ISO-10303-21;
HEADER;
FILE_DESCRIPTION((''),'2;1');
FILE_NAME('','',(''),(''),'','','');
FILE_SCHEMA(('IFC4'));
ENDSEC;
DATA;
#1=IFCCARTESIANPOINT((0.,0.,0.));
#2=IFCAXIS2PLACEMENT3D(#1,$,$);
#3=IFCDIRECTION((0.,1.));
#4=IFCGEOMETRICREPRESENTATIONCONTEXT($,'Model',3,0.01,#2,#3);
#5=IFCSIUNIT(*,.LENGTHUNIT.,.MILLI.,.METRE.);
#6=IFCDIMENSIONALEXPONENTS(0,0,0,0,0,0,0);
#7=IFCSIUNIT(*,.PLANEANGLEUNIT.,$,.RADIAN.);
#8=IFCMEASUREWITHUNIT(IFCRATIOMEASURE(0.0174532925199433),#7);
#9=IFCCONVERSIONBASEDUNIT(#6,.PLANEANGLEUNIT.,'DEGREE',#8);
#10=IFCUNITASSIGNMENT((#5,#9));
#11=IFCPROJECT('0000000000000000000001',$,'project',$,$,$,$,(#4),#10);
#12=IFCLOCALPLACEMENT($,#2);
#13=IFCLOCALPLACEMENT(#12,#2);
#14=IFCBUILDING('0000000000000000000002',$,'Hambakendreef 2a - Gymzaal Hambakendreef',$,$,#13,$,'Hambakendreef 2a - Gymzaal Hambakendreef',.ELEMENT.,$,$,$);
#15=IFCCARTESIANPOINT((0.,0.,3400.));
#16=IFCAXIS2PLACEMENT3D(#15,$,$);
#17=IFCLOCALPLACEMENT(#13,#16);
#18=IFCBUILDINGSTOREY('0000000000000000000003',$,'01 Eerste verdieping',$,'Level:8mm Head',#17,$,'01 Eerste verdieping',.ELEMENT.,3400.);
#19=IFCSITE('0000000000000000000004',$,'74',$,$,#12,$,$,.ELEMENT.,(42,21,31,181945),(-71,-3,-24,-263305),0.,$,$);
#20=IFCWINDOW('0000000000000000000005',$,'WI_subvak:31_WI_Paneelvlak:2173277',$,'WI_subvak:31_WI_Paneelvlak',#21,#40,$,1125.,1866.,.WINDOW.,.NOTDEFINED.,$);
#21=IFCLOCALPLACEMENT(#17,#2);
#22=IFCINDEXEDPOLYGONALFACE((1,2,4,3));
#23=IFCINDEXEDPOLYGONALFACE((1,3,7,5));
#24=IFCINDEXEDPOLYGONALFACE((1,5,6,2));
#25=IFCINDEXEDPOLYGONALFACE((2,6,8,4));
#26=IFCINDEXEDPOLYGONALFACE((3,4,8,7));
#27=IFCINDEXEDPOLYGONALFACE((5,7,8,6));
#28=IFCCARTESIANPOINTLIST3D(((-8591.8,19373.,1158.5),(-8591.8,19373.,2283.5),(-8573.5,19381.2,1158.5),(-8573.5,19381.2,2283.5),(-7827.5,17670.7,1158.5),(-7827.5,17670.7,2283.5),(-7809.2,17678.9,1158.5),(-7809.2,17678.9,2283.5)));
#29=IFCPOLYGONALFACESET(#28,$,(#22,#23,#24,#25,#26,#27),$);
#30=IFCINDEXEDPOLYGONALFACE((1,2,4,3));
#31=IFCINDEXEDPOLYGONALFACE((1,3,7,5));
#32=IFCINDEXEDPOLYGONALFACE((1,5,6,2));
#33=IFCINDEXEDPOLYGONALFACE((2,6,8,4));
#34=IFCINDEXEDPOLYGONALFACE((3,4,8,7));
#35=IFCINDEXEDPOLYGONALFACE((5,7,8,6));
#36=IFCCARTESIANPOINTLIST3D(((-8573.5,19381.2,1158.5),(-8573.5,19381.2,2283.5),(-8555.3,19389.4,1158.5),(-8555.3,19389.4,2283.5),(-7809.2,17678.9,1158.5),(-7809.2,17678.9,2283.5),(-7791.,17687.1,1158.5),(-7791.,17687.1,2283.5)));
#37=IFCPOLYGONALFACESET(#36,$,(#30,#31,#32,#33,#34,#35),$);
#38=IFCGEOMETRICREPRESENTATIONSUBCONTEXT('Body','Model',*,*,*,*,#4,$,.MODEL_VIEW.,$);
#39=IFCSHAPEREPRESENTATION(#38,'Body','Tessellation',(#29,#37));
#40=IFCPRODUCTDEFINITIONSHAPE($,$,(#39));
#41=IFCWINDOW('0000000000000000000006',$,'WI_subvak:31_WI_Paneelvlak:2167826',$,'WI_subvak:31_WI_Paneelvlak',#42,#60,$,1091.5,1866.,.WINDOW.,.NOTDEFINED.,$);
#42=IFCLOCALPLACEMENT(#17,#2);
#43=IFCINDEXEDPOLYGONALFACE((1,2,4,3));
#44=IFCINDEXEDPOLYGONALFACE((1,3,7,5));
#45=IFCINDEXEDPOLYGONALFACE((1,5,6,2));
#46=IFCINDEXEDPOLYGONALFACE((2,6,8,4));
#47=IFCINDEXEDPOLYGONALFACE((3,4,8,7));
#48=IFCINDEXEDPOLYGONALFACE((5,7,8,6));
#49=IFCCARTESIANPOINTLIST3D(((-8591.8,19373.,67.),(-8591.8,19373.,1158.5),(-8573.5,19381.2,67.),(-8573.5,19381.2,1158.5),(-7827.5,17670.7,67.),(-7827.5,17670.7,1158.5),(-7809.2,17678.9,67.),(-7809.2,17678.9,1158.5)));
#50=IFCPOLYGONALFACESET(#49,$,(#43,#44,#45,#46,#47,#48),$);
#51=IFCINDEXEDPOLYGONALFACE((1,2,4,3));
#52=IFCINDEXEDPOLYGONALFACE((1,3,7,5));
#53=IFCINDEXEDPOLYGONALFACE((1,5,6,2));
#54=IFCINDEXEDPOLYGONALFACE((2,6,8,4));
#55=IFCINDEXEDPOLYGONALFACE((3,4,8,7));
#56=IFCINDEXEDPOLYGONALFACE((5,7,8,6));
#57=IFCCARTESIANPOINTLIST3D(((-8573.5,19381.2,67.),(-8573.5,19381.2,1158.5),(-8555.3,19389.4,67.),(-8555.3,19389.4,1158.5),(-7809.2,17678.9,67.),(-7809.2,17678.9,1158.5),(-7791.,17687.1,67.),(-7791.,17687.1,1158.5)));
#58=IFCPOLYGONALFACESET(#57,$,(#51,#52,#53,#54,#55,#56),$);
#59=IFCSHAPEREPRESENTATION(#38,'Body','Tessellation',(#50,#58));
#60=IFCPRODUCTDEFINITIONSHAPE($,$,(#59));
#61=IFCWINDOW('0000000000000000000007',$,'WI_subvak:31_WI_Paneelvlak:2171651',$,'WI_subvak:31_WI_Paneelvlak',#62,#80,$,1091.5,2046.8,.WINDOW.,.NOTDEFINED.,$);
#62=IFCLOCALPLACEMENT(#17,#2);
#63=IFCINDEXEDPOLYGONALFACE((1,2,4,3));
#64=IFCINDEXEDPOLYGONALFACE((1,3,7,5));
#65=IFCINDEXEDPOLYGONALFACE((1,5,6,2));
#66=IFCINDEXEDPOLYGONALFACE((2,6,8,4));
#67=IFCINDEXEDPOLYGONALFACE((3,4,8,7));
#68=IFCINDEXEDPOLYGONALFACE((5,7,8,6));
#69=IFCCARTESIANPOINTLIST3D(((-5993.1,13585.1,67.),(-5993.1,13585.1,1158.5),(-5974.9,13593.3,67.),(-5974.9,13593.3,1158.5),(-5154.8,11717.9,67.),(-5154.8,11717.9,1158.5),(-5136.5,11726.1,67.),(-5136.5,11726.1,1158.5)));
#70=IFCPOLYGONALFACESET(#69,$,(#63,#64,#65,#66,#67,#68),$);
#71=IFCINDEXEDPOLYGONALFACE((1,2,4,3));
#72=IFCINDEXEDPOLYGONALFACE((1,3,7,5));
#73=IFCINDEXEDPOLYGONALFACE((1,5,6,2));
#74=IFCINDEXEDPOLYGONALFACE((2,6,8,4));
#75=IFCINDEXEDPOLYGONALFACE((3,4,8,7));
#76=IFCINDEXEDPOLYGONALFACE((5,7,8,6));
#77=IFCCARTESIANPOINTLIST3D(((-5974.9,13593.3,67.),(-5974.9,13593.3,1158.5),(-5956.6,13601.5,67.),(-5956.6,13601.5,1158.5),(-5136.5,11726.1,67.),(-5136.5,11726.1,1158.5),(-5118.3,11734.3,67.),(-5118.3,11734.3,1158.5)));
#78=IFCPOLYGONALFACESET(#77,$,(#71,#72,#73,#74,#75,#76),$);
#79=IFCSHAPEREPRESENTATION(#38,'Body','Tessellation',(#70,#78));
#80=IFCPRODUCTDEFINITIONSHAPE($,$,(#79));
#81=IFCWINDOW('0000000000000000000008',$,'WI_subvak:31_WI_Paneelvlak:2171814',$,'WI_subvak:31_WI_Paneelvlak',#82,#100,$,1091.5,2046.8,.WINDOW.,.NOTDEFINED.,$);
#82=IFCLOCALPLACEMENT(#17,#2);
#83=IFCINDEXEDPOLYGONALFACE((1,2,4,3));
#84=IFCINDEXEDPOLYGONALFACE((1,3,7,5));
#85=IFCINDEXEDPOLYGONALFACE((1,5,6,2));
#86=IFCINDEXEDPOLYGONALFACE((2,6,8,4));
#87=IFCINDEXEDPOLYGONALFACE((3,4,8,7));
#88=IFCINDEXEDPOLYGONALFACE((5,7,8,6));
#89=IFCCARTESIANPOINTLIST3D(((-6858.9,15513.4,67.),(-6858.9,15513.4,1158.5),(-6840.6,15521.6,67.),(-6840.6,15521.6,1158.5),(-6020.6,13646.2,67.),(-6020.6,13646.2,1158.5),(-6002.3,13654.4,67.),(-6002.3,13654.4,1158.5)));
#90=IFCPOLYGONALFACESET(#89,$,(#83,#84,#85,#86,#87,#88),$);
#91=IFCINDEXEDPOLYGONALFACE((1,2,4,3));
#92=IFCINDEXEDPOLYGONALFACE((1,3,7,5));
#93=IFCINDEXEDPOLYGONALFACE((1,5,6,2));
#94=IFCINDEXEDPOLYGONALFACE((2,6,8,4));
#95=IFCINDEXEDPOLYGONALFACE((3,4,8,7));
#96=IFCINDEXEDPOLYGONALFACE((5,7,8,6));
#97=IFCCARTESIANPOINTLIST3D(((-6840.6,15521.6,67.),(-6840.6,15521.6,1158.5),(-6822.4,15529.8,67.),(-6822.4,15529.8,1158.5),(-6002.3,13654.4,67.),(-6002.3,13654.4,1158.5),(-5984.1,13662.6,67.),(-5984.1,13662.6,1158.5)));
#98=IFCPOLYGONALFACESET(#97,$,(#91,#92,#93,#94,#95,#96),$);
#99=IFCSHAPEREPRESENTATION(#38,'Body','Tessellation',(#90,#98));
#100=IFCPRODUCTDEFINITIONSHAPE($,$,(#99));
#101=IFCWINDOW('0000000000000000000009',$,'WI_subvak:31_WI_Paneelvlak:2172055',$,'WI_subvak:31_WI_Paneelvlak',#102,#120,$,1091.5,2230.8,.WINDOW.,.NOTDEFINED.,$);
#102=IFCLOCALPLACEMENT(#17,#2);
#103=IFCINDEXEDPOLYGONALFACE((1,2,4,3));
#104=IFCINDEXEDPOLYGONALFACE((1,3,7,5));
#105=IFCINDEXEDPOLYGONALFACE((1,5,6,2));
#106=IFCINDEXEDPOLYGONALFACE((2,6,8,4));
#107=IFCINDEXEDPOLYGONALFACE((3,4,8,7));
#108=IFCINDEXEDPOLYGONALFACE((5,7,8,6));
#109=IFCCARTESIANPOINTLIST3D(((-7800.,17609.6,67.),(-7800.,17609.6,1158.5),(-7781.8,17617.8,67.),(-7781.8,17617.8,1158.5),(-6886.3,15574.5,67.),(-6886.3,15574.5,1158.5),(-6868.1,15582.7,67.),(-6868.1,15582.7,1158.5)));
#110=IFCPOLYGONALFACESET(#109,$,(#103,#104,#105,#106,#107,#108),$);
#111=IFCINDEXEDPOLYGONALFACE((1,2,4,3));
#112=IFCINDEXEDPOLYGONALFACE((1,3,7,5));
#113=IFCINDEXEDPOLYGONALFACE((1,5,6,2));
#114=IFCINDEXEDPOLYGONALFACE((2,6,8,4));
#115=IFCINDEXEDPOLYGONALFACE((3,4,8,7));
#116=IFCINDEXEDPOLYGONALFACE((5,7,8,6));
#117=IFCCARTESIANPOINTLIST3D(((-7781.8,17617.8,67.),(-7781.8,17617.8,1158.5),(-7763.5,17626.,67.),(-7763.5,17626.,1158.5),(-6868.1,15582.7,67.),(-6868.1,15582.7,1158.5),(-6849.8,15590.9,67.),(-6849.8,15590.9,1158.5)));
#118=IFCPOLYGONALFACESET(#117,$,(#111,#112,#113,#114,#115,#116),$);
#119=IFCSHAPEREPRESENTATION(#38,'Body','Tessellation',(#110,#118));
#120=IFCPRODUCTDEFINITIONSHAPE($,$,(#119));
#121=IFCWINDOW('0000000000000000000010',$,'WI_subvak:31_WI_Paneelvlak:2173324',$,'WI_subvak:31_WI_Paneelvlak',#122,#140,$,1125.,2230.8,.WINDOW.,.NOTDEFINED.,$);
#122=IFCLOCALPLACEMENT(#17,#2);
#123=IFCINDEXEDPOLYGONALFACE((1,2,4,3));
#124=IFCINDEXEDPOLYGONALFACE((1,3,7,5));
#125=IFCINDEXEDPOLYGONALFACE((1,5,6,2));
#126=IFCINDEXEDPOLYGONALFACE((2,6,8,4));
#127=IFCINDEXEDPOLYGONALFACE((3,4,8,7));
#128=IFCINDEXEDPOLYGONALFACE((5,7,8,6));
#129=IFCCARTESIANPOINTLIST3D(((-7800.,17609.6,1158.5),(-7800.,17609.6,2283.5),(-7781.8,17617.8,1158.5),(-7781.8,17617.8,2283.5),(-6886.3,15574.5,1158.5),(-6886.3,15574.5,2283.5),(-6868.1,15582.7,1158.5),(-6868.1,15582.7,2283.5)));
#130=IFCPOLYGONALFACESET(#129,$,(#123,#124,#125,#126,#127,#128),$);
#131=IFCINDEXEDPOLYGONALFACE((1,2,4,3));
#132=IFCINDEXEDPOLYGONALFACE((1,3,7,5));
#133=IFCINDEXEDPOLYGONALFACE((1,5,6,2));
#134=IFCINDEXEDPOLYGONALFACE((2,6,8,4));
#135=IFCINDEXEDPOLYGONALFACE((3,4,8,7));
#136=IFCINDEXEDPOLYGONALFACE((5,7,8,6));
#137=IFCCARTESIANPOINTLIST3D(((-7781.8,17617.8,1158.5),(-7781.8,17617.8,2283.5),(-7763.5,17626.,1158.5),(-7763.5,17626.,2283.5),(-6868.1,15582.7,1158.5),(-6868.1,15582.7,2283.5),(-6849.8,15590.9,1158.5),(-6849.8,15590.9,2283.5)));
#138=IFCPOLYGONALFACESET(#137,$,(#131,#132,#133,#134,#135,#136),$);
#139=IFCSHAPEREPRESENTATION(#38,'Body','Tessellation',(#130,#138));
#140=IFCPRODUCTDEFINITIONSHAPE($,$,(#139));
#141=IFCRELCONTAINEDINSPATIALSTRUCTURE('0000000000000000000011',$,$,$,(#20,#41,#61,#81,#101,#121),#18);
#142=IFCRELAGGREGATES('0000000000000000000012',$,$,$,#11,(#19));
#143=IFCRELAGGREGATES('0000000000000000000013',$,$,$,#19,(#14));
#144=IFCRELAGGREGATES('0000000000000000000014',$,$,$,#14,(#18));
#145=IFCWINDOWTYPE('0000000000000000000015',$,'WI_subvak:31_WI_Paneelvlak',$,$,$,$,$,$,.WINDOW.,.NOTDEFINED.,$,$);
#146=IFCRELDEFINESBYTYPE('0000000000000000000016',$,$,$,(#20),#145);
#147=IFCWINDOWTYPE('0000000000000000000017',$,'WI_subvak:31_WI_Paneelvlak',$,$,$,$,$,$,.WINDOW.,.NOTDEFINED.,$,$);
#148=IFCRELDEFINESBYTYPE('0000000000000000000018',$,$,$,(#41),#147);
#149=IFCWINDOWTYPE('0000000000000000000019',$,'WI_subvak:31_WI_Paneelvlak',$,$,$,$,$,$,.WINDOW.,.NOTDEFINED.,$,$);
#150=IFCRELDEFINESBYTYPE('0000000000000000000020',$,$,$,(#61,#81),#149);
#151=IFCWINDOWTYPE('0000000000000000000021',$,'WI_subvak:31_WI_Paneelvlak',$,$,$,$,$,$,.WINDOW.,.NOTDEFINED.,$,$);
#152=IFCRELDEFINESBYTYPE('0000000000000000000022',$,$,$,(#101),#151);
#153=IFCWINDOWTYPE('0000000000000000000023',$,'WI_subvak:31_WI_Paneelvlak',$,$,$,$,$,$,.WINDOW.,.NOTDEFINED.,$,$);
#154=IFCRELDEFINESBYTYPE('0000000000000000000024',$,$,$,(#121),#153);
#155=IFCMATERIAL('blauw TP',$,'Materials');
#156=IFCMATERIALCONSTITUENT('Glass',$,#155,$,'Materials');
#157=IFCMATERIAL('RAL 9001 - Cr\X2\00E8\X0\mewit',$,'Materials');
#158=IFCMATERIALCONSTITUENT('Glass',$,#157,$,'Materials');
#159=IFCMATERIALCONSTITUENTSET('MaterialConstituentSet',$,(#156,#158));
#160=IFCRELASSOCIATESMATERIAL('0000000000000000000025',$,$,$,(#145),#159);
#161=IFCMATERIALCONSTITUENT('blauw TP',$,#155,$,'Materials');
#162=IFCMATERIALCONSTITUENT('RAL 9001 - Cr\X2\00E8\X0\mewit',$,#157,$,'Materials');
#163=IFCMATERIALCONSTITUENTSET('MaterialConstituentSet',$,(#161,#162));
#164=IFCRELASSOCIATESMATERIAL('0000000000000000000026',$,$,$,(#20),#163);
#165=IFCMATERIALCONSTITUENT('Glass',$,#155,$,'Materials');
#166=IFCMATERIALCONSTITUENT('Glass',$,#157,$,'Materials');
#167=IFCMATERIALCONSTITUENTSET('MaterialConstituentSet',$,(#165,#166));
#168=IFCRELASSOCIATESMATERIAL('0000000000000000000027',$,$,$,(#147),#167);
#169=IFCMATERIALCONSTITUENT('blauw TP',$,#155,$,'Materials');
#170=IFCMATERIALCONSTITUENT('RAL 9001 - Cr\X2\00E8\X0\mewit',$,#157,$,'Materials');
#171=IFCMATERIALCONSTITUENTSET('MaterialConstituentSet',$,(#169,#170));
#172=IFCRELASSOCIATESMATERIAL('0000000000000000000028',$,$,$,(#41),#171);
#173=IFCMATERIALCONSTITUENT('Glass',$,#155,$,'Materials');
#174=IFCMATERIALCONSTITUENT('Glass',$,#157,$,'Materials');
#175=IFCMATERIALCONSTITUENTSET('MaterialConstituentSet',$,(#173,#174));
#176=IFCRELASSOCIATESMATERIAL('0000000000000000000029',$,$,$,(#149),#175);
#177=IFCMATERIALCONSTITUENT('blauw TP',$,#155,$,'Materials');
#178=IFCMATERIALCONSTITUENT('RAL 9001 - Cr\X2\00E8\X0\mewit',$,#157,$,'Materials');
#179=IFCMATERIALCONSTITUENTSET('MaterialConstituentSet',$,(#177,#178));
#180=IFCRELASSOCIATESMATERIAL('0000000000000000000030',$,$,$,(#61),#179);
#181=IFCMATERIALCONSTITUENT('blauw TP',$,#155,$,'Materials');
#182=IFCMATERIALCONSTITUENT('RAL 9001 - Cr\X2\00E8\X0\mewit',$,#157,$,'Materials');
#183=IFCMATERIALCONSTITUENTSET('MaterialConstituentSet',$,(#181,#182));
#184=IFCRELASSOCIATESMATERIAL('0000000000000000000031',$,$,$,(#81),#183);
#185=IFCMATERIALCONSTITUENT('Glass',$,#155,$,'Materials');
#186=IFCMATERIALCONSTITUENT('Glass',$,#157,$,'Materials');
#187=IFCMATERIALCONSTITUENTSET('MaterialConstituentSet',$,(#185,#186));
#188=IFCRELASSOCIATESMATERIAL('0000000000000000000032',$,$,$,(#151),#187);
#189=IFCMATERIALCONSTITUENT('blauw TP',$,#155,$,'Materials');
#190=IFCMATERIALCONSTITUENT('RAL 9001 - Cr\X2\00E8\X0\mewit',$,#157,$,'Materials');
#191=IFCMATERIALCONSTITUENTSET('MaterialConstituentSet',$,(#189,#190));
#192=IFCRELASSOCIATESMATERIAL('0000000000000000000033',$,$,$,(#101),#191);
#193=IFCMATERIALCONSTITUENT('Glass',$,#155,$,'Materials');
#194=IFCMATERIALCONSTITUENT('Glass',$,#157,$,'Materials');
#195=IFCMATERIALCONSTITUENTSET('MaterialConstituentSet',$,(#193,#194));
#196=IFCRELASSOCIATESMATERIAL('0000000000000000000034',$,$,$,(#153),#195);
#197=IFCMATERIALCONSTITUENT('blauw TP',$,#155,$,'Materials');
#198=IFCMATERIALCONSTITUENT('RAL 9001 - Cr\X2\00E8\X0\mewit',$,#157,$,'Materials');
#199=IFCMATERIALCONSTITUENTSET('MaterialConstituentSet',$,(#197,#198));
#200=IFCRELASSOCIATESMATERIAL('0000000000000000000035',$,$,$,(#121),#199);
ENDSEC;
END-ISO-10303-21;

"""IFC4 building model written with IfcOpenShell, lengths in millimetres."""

from ifc_helpers import new_model, entity, si_unit, converted_unit, direction, frame, origin, place, context, subcontext, project, spatial, indexed_curve, outline, extrude, source, transform, mapped, material, constituent, constituent_set, type_object, type_shapes, element, save


model = new_model("IFC4")

# Units and contexts
model_context = context("Model", 3, precision=0.01, world=origin(), true_north=direction((0.0, 1.0)))
body_context = subcontext(model_context, "Body", "Model", "MODEL_VIEW")
ifc_project = project(units=[si_unit("LENGTHUNIT", "METRE", prefix="MILLI"), converted_unit("PLANEANGLEUNIT", "DEGREE", entity("IfcRatioMeasure", 0.0174532925199433), si_unit("PLANEANGLEUNIT", "RADIAN"), dimensions=[0, 0, 0, 0, 0, 0, 0])], contexts=[model_context])

# Site, building, storey
site_placement = place(None, origin())
site = spatial("IfcSite", under=ifc_project, at=site_placement, Name="74", CompositionType="ELEMENT", RefLatitude=(42, 21, 31, 181945), RefLongitude=(-71, -3, -24, -263305), RefElevation=0.0)
building_placement = place(site_placement, origin())
building = spatial("IfcBuilding", under=site, at=building_placement, Name="Hambakendreef 2a - Gymzaal Hambakendreef", LongName="Hambakendreef 2a - Gymzaal Hambakendreef", CompositionType="ELEMENT")
storey_placement = place(building_placement, frame((0.0, 0.0, 3400.0)))
storey = spatial("IfcBuildingStorey", under=building, at=storey_placement, Name="01 Eerste verdieping", ObjectType="Level:8mm Head", LongName="01 Eerste verdieping", CompositionType="ELEMENT", Elevation=3400.0)

# Windows
ifc_material_1 = material(Name="blauw TP", Category="Materials")
ifc_constituent_1 = constituent(ifc_material_1, Name="blauw TP", Category="Materials")
ifc_material_2 = material(Name="RAL 9001 - Crèmewit", Category="Materials")
ifc_constituent_2 = constituent(ifc_material_2, Name="RAL 9001 - Crèmewit", Category="Materials")
ifc_constituent_set_1 = constituent_set(constituents=[ifc_constituent_1, ifc_constituent_2], Name="MaterialConstituentSet")
ifc_constituent_3 = constituent(ifc_material_1, Name="Glass", Category="Materials")
ifc_constituent_4 = constituent(ifc_material_2, Name="Glass", Category="Materials")
ifc_constituent_set_2 = constituent_set(constituents=[ifc_constituent_3, ifc_constituent_4], Name="MaterialConstituentSet")
window_type_1 = type_object("IfcWindowType", Name="WI_subvak:31_WI_Paneelvlak", PartitioningType="NOTDEFINED", PredefinedType="WINDOW", material=ifc_constituent_set_2)
shared_shape_1 = source(origin(), body_context, "Body", "SweptSolid", [
    extrude(outline(indexed_curve([(-933.0, -10.0), (933.0, -10.0), (933.0, 10.0), (-933.0, 10.0), (-933.0, -10.0)], self_intersect=False)), frame((0.0, -10.0, 0.0)), (0.0, 0.0, 1.0), 1125.0),
    extrude(outline(indexed_curve([(-933.0, -10.0), (933.0, -10.0), (933.0, 10.0), (-933.0, 10.0), (-933.0, -10.0)], self_intersect=False)), frame((0.0, 10.0, 0.0)), (0.0, 0.0, 1.0), 1125.0),
])
type_shapes(window_type_1, [shared_shape_1])
window_1_placement = place(storey_placement, frame((-8191.4, 18530.0, 1158.5), z_axis=(0.0, 0.0, 1.0), x_axis=(0.40959, -0.91227, 0.0)))
element("IfcWindow", 1, at=window_1_placement, inside=storey, type_object=window_type_1, material=ifc_constituent_set_1, Name="WI_subvak:31_WI_Paneelvlak:2173277", ObjectType="WI_subvak:31_WI_Paneelvlak", OverallHeight=1125.0, OverallWidth=1866.0, PartitioningType="NOTDEFINED", PredefinedType="WINDOW", context=body_context, shape_type="MappedRepresentation", body=[
    mapped(shared_shape_1, transform((0.0, 0.0, 0.0), scale=1.0)),
])
ifc_constituent_5 = constituent(ifc_material_1, Name="blauw TP", Category="Materials")
ifc_constituent_6 = constituent(ifc_material_2, Name="RAL 9001 - Crèmewit", Category="Materials")
ifc_constituent_set_3 = constituent_set(constituents=[ifc_constituent_5, ifc_constituent_6], Name="MaterialConstituentSet")
ifc_constituent_7 = constituent(ifc_material_1, Name="Glass", Category="Materials")
ifc_constituent_8 = constituent(ifc_material_2, Name="Glass", Category="Materials")
ifc_constituent_set_4 = constituent_set(constituents=[ifc_constituent_7, ifc_constituent_8], Name="MaterialConstituentSet")
window_type_2 = type_object("IfcWindowType", Name="WI_subvak:31_WI_Paneelvlak", PartitioningType="NOTDEFINED", PredefinedType="WINDOW", material=ifc_constituent_set_4)
shared_shape_2 = source(origin(), body_context, "Body", "SweptSolid", [
    extrude(outline(indexed_curve([(-933.0, -10.0), (933.0, -10.0), (933.0, 10.0), (-933.0, 10.0), (-933.0, -10.0)], self_intersect=False)), frame((0.0, -10.0, 0.0)), (0.0, 0.0, 1.0), 1091.5),
    extrude(outline(indexed_curve([(-933.0, -10.0), (933.0, -10.0), (933.0, 10.0), (-933.0, 10.0), (-933.0, -10.0)], self_intersect=False)), frame((0.0, 10.0, 0.0)), (0.0, 0.0, 1.0), 1091.5),
])
type_shapes(window_type_2, [shared_shape_2])
window_2_placement = place(storey_placement, frame((-8191.4, 18530.0, 67.0), z_axis=(0.0, 0.0, 1.0), x_axis=(0.40959, -0.91227, 0.0)))
element("IfcWindow", 2, at=window_2_placement, inside=storey, type_object=window_type_2, material=ifc_constituent_set_3, Name="WI_subvak:31_WI_Paneelvlak:2167826", ObjectType="WI_subvak:31_WI_Paneelvlak", OverallHeight=1091.5, OverallWidth=1866.0, PartitioningType="NOTDEFINED", PredefinedType="WINDOW", context=body_context, shape_type="MappedRepresentation", body=[
    mapped(shared_shape_2, transform((0.0, 0.0, 0.0), scale=1.0)),
])
ifc_constituent_9 = constituent(ifc_material_1, Name="blauw TP", Category="Materials")
ifc_constituent_10 = constituent(ifc_material_2, Name="RAL 9001 - Crèmewit", Category="Materials")
ifc_constituent_set_5 = constituent_set(constituents=[ifc_constituent_9, ifc_constituent_10], Name="MaterialConstituentSet")
ifc_constituent_11 = constituent(ifc_material_1, Name="Glass", Category="Materials")
ifc_constituent_12 = constituent(ifc_material_2, Name="Glass", Category="Materials")
ifc_constituent_set_6 = constituent_set(constituents=[ifc_constituent_11, ifc_constituent_12], Name="MaterialConstituentSet")
window_type_3 = type_object("IfcWindowType", Name="WI_subvak:31_WI_Paneelvlak", PartitioningType="NOTDEFINED", PredefinedType="WINDOW", material=ifc_constituent_set_6)
shared_shape_3 = source(origin(), body_context, "Body", "SweptSolid", [
    extrude(outline(indexed_curve([(-1023.4, -10.0), (1023.4, -10.0), (1023.4, 10.0), (-1023.4, 10.0), (-1023.4, -10.0)], self_intersect=False)), frame((0.0, -10.0, 0.0)), (0.0, 0.0, 1.0), 1091.5),
    extrude(outline(indexed_curve([(-1023.4, -10.0), (1023.4, -10.0), (1023.4, 10.0), (-1023.4, 10.0), (-1023.4, -10.0)], self_intersect=False)), frame((0.0, 10.0, 0.0)), (0.0, 0.0, 1.0), 1091.5),
])
type_shapes(window_type_3, [shared_shape_3])
window_3_placement = place(storey_placement, frame((-5555.7, 12659.7, 67.0), z_axis=(0.0, 0.0, 1.0), x_axis=(0.40959, -0.91227, 0.0)))
element("IfcWindow", 3, at=window_3_placement, inside=storey, type_object=window_type_3, material=ifc_constituent_set_5, Name="WI_subvak:31_WI_Paneelvlak:2171651", ObjectType="WI_subvak:31_WI_Paneelvlak", OverallHeight=1091.5, OverallWidth=2046.8, PartitioningType="NOTDEFINED", PredefinedType="WINDOW", context=body_context, shape_type="MappedRepresentation", body=[
    mapped(shared_shape_3, transform((0.0, 0.0, 0.0), scale=1.0)),
])
ifc_constituent_13 = constituent(ifc_material_1, Name="blauw TP", Category="Materials")
ifc_constituent_14 = constituent(ifc_material_2, Name="RAL 9001 - Crèmewit", Category="Materials")
ifc_constituent_set_7 = constituent_set(constituents=[ifc_constituent_13, ifc_constituent_14], Name="MaterialConstituentSet")
window_4_placement = place(storey_placement, frame((-6421.5, 14588.0, 67.0), z_axis=(0.0, 0.0, 1.0), x_axis=(0.40959, -0.91227, 0.0)))
element("IfcWindow", 4, at=window_4_placement, inside=storey, type_object=window_type_3, material=ifc_constituent_set_7, Name="WI_subvak:31_WI_Paneelvlak:2171814", ObjectType="WI_subvak:31_WI_Paneelvlak", OverallHeight=1091.5, OverallWidth=2046.8, PartitioningType="NOTDEFINED", PredefinedType="WINDOW", context=body_context, shape_type="MappedRepresentation", body=[
    mapped(shared_shape_3, transform((0.0, 0.0, 0.0), scale=1.0)),
])
ifc_constituent_15 = constituent(ifc_material_1, Name="blauw TP", Category="Materials")
ifc_constituent_16 = constituent(ifc_material_2, Name="RAL 9001 - Crèmewit", Category="Materials")
ifc_constituent_set_8 = constituent_set(constituents=[ifc_constituent_15, ifc_constituent_16], Name="MaterialConstituentSet")
ifc_constituent_17 = constituent(ifc_material_1, Name="Glass", Category="Materials")
ifc_constituent_18 = constituent(ifc_material_2, Name="Glass", Category="Materials")
ifc_constituent_set_9 = constituent_set(constituents=[ifc_constituent_17, ifc_constituent_18], Name="MaterialConstituentSet")
window_type_4 = type_object("IfcWindowType", Name="WI_subvak:31_WI_Paneelvlak", PartitioningType="NOTDEFINED", PredefinedType="WINDOW", material=ifc_constituent_set_9)
shared_shape_4 = source(origin(), body_context, "Body", "SweptSolid", [
    extrude(outline(indexed_curve([(-1115.4, -10.0), (1115.4, -10.0), (1115.4, 10.0), (-1115.4, 10.0), (-1115.4, -10.0)], self_intersect=False)), frame((0.0, -10.0, 0.0)), (0.0, 0.0, 1.0), 1091.5),
    extrude(outline(indexed_curve([(-1115.4, -10.0), (1115.4, -10.0), (1115.4, 10.0), (-1115.4, 10.0), (-1115.4, -10.0)], self_intersect=False)), frame((0.0, 10.0, 0.0)), (0.0, 0.0, 1.0), 1091.5),
])
type_shapes(window_type_4, [shared_shape_4])
window_5_placement = place(storey_placement, frame((-7324.9, 16600.3, 67.0), z_axis=(0.0, 0.0, 1.0), x_axis=(0.40959, -0.91227, 0.0)))
element("IfcWindow", 5, at=window_5_placement, inside=storey, type_object=window_type_4, material=ifc_constituent_set_8, Name="WI_subvak:31_WI_Paneelvlak:2172055", ObjectType="WI_subvak:31_WI_Paneelvlak", OverallHeight=1091.5, OverallWidth=2230.8, PartitioningType="NOTDEFINED", PredefinedType="WINDOW", context=body_context, shape_type="MappedRepresentation", body=[
    mapped(shared_shape_4, transform((0.0, 0.0, 0.0), scale=1.0)),
])
ifc_constituent_19 = constituent(ifc_material_1, Name="blauw TP", Category="Materials")
ifc_constituent_20 = constituent(ifc_material_2, Name="RAL 9001 - Crèmewit", Category="Materials")
ifc_constituent_set_10 = constituent_set(constituents=[ifc_constituent_19, ifc_constituent_20], Name="MaterialConstituentSet")
ifc_constituent_21 = constituent(ifc_material_1, Name="Glass", Category="Materials")
ifc_constituent_22 = constituent(ifc_material_2, Name="Glass", Category="Materials")
ifc_constituent_set_11 = constituent_set(constituents=[ifc_constituent_21, ifc_constituent_22], Name="MaterialConstituentSet")
window_type_5 = type_object("IfcWindowType", Name="WI_subvak:31_WI_Paneelvlak", PartitioningType="NOTDEFINED", PredefinedType="WINDOW", material=ifc_constituent_set_11)
shared_shape_5 = source(origin(), body_context, "Body", "SweptSolid", [
    extrude(outline(indexed_curve([(-1115.4, -10.0), (1115.4, -10.0), (1115.4, 10.0), (-1115.4, 10.0), (-1115.4, -10.0)], self_intersect=False)), frame((0.0, -10.0, 0.0)), (0.0, 0.0, 1.0), 1125.0),
    extrude(outline(indexed_curve([(-1115.4, -10.0), (1115.4, -10.0), (1115.4, 10.0), (-1115.4, 10.0), (-1115.4, -10.0)], self_intersect=False)), frame((0.0, 10.0, 0.0)), (0.0, 0.0, 1.0), 1125.0),
])
type_shapes(window_type_5, [shared_shape_5])
window_6_placement = place(storey_placement, frame((-7324.9, 16600.3, 1158.5), z_axis=(0.0, 0.0, 1.0), x_axis=(0.40959, -0.91227, 0.0)))
element("IfcWindow", 6, at=window_6_placement, inside=storey, type_object=window_type_5, material=ifc_constituent_set_10, Name="WI_subvak:31_WI_Paneelvlak:2173324", ObjectType="WI_subvak:31_WI_Paneelvlak", OverallHeight=1125.0, OverallWidth=2230.8, PartitioningType="NOTDEFINED", PredefinedType="WINDOW", context=body_context, shape_type="MappedRepresentation", body=[
    mapped(shared_shape_5, transform((0.0, 0.0, 0.0), scale=1.0)),
])

save(model, "model.ifc")
